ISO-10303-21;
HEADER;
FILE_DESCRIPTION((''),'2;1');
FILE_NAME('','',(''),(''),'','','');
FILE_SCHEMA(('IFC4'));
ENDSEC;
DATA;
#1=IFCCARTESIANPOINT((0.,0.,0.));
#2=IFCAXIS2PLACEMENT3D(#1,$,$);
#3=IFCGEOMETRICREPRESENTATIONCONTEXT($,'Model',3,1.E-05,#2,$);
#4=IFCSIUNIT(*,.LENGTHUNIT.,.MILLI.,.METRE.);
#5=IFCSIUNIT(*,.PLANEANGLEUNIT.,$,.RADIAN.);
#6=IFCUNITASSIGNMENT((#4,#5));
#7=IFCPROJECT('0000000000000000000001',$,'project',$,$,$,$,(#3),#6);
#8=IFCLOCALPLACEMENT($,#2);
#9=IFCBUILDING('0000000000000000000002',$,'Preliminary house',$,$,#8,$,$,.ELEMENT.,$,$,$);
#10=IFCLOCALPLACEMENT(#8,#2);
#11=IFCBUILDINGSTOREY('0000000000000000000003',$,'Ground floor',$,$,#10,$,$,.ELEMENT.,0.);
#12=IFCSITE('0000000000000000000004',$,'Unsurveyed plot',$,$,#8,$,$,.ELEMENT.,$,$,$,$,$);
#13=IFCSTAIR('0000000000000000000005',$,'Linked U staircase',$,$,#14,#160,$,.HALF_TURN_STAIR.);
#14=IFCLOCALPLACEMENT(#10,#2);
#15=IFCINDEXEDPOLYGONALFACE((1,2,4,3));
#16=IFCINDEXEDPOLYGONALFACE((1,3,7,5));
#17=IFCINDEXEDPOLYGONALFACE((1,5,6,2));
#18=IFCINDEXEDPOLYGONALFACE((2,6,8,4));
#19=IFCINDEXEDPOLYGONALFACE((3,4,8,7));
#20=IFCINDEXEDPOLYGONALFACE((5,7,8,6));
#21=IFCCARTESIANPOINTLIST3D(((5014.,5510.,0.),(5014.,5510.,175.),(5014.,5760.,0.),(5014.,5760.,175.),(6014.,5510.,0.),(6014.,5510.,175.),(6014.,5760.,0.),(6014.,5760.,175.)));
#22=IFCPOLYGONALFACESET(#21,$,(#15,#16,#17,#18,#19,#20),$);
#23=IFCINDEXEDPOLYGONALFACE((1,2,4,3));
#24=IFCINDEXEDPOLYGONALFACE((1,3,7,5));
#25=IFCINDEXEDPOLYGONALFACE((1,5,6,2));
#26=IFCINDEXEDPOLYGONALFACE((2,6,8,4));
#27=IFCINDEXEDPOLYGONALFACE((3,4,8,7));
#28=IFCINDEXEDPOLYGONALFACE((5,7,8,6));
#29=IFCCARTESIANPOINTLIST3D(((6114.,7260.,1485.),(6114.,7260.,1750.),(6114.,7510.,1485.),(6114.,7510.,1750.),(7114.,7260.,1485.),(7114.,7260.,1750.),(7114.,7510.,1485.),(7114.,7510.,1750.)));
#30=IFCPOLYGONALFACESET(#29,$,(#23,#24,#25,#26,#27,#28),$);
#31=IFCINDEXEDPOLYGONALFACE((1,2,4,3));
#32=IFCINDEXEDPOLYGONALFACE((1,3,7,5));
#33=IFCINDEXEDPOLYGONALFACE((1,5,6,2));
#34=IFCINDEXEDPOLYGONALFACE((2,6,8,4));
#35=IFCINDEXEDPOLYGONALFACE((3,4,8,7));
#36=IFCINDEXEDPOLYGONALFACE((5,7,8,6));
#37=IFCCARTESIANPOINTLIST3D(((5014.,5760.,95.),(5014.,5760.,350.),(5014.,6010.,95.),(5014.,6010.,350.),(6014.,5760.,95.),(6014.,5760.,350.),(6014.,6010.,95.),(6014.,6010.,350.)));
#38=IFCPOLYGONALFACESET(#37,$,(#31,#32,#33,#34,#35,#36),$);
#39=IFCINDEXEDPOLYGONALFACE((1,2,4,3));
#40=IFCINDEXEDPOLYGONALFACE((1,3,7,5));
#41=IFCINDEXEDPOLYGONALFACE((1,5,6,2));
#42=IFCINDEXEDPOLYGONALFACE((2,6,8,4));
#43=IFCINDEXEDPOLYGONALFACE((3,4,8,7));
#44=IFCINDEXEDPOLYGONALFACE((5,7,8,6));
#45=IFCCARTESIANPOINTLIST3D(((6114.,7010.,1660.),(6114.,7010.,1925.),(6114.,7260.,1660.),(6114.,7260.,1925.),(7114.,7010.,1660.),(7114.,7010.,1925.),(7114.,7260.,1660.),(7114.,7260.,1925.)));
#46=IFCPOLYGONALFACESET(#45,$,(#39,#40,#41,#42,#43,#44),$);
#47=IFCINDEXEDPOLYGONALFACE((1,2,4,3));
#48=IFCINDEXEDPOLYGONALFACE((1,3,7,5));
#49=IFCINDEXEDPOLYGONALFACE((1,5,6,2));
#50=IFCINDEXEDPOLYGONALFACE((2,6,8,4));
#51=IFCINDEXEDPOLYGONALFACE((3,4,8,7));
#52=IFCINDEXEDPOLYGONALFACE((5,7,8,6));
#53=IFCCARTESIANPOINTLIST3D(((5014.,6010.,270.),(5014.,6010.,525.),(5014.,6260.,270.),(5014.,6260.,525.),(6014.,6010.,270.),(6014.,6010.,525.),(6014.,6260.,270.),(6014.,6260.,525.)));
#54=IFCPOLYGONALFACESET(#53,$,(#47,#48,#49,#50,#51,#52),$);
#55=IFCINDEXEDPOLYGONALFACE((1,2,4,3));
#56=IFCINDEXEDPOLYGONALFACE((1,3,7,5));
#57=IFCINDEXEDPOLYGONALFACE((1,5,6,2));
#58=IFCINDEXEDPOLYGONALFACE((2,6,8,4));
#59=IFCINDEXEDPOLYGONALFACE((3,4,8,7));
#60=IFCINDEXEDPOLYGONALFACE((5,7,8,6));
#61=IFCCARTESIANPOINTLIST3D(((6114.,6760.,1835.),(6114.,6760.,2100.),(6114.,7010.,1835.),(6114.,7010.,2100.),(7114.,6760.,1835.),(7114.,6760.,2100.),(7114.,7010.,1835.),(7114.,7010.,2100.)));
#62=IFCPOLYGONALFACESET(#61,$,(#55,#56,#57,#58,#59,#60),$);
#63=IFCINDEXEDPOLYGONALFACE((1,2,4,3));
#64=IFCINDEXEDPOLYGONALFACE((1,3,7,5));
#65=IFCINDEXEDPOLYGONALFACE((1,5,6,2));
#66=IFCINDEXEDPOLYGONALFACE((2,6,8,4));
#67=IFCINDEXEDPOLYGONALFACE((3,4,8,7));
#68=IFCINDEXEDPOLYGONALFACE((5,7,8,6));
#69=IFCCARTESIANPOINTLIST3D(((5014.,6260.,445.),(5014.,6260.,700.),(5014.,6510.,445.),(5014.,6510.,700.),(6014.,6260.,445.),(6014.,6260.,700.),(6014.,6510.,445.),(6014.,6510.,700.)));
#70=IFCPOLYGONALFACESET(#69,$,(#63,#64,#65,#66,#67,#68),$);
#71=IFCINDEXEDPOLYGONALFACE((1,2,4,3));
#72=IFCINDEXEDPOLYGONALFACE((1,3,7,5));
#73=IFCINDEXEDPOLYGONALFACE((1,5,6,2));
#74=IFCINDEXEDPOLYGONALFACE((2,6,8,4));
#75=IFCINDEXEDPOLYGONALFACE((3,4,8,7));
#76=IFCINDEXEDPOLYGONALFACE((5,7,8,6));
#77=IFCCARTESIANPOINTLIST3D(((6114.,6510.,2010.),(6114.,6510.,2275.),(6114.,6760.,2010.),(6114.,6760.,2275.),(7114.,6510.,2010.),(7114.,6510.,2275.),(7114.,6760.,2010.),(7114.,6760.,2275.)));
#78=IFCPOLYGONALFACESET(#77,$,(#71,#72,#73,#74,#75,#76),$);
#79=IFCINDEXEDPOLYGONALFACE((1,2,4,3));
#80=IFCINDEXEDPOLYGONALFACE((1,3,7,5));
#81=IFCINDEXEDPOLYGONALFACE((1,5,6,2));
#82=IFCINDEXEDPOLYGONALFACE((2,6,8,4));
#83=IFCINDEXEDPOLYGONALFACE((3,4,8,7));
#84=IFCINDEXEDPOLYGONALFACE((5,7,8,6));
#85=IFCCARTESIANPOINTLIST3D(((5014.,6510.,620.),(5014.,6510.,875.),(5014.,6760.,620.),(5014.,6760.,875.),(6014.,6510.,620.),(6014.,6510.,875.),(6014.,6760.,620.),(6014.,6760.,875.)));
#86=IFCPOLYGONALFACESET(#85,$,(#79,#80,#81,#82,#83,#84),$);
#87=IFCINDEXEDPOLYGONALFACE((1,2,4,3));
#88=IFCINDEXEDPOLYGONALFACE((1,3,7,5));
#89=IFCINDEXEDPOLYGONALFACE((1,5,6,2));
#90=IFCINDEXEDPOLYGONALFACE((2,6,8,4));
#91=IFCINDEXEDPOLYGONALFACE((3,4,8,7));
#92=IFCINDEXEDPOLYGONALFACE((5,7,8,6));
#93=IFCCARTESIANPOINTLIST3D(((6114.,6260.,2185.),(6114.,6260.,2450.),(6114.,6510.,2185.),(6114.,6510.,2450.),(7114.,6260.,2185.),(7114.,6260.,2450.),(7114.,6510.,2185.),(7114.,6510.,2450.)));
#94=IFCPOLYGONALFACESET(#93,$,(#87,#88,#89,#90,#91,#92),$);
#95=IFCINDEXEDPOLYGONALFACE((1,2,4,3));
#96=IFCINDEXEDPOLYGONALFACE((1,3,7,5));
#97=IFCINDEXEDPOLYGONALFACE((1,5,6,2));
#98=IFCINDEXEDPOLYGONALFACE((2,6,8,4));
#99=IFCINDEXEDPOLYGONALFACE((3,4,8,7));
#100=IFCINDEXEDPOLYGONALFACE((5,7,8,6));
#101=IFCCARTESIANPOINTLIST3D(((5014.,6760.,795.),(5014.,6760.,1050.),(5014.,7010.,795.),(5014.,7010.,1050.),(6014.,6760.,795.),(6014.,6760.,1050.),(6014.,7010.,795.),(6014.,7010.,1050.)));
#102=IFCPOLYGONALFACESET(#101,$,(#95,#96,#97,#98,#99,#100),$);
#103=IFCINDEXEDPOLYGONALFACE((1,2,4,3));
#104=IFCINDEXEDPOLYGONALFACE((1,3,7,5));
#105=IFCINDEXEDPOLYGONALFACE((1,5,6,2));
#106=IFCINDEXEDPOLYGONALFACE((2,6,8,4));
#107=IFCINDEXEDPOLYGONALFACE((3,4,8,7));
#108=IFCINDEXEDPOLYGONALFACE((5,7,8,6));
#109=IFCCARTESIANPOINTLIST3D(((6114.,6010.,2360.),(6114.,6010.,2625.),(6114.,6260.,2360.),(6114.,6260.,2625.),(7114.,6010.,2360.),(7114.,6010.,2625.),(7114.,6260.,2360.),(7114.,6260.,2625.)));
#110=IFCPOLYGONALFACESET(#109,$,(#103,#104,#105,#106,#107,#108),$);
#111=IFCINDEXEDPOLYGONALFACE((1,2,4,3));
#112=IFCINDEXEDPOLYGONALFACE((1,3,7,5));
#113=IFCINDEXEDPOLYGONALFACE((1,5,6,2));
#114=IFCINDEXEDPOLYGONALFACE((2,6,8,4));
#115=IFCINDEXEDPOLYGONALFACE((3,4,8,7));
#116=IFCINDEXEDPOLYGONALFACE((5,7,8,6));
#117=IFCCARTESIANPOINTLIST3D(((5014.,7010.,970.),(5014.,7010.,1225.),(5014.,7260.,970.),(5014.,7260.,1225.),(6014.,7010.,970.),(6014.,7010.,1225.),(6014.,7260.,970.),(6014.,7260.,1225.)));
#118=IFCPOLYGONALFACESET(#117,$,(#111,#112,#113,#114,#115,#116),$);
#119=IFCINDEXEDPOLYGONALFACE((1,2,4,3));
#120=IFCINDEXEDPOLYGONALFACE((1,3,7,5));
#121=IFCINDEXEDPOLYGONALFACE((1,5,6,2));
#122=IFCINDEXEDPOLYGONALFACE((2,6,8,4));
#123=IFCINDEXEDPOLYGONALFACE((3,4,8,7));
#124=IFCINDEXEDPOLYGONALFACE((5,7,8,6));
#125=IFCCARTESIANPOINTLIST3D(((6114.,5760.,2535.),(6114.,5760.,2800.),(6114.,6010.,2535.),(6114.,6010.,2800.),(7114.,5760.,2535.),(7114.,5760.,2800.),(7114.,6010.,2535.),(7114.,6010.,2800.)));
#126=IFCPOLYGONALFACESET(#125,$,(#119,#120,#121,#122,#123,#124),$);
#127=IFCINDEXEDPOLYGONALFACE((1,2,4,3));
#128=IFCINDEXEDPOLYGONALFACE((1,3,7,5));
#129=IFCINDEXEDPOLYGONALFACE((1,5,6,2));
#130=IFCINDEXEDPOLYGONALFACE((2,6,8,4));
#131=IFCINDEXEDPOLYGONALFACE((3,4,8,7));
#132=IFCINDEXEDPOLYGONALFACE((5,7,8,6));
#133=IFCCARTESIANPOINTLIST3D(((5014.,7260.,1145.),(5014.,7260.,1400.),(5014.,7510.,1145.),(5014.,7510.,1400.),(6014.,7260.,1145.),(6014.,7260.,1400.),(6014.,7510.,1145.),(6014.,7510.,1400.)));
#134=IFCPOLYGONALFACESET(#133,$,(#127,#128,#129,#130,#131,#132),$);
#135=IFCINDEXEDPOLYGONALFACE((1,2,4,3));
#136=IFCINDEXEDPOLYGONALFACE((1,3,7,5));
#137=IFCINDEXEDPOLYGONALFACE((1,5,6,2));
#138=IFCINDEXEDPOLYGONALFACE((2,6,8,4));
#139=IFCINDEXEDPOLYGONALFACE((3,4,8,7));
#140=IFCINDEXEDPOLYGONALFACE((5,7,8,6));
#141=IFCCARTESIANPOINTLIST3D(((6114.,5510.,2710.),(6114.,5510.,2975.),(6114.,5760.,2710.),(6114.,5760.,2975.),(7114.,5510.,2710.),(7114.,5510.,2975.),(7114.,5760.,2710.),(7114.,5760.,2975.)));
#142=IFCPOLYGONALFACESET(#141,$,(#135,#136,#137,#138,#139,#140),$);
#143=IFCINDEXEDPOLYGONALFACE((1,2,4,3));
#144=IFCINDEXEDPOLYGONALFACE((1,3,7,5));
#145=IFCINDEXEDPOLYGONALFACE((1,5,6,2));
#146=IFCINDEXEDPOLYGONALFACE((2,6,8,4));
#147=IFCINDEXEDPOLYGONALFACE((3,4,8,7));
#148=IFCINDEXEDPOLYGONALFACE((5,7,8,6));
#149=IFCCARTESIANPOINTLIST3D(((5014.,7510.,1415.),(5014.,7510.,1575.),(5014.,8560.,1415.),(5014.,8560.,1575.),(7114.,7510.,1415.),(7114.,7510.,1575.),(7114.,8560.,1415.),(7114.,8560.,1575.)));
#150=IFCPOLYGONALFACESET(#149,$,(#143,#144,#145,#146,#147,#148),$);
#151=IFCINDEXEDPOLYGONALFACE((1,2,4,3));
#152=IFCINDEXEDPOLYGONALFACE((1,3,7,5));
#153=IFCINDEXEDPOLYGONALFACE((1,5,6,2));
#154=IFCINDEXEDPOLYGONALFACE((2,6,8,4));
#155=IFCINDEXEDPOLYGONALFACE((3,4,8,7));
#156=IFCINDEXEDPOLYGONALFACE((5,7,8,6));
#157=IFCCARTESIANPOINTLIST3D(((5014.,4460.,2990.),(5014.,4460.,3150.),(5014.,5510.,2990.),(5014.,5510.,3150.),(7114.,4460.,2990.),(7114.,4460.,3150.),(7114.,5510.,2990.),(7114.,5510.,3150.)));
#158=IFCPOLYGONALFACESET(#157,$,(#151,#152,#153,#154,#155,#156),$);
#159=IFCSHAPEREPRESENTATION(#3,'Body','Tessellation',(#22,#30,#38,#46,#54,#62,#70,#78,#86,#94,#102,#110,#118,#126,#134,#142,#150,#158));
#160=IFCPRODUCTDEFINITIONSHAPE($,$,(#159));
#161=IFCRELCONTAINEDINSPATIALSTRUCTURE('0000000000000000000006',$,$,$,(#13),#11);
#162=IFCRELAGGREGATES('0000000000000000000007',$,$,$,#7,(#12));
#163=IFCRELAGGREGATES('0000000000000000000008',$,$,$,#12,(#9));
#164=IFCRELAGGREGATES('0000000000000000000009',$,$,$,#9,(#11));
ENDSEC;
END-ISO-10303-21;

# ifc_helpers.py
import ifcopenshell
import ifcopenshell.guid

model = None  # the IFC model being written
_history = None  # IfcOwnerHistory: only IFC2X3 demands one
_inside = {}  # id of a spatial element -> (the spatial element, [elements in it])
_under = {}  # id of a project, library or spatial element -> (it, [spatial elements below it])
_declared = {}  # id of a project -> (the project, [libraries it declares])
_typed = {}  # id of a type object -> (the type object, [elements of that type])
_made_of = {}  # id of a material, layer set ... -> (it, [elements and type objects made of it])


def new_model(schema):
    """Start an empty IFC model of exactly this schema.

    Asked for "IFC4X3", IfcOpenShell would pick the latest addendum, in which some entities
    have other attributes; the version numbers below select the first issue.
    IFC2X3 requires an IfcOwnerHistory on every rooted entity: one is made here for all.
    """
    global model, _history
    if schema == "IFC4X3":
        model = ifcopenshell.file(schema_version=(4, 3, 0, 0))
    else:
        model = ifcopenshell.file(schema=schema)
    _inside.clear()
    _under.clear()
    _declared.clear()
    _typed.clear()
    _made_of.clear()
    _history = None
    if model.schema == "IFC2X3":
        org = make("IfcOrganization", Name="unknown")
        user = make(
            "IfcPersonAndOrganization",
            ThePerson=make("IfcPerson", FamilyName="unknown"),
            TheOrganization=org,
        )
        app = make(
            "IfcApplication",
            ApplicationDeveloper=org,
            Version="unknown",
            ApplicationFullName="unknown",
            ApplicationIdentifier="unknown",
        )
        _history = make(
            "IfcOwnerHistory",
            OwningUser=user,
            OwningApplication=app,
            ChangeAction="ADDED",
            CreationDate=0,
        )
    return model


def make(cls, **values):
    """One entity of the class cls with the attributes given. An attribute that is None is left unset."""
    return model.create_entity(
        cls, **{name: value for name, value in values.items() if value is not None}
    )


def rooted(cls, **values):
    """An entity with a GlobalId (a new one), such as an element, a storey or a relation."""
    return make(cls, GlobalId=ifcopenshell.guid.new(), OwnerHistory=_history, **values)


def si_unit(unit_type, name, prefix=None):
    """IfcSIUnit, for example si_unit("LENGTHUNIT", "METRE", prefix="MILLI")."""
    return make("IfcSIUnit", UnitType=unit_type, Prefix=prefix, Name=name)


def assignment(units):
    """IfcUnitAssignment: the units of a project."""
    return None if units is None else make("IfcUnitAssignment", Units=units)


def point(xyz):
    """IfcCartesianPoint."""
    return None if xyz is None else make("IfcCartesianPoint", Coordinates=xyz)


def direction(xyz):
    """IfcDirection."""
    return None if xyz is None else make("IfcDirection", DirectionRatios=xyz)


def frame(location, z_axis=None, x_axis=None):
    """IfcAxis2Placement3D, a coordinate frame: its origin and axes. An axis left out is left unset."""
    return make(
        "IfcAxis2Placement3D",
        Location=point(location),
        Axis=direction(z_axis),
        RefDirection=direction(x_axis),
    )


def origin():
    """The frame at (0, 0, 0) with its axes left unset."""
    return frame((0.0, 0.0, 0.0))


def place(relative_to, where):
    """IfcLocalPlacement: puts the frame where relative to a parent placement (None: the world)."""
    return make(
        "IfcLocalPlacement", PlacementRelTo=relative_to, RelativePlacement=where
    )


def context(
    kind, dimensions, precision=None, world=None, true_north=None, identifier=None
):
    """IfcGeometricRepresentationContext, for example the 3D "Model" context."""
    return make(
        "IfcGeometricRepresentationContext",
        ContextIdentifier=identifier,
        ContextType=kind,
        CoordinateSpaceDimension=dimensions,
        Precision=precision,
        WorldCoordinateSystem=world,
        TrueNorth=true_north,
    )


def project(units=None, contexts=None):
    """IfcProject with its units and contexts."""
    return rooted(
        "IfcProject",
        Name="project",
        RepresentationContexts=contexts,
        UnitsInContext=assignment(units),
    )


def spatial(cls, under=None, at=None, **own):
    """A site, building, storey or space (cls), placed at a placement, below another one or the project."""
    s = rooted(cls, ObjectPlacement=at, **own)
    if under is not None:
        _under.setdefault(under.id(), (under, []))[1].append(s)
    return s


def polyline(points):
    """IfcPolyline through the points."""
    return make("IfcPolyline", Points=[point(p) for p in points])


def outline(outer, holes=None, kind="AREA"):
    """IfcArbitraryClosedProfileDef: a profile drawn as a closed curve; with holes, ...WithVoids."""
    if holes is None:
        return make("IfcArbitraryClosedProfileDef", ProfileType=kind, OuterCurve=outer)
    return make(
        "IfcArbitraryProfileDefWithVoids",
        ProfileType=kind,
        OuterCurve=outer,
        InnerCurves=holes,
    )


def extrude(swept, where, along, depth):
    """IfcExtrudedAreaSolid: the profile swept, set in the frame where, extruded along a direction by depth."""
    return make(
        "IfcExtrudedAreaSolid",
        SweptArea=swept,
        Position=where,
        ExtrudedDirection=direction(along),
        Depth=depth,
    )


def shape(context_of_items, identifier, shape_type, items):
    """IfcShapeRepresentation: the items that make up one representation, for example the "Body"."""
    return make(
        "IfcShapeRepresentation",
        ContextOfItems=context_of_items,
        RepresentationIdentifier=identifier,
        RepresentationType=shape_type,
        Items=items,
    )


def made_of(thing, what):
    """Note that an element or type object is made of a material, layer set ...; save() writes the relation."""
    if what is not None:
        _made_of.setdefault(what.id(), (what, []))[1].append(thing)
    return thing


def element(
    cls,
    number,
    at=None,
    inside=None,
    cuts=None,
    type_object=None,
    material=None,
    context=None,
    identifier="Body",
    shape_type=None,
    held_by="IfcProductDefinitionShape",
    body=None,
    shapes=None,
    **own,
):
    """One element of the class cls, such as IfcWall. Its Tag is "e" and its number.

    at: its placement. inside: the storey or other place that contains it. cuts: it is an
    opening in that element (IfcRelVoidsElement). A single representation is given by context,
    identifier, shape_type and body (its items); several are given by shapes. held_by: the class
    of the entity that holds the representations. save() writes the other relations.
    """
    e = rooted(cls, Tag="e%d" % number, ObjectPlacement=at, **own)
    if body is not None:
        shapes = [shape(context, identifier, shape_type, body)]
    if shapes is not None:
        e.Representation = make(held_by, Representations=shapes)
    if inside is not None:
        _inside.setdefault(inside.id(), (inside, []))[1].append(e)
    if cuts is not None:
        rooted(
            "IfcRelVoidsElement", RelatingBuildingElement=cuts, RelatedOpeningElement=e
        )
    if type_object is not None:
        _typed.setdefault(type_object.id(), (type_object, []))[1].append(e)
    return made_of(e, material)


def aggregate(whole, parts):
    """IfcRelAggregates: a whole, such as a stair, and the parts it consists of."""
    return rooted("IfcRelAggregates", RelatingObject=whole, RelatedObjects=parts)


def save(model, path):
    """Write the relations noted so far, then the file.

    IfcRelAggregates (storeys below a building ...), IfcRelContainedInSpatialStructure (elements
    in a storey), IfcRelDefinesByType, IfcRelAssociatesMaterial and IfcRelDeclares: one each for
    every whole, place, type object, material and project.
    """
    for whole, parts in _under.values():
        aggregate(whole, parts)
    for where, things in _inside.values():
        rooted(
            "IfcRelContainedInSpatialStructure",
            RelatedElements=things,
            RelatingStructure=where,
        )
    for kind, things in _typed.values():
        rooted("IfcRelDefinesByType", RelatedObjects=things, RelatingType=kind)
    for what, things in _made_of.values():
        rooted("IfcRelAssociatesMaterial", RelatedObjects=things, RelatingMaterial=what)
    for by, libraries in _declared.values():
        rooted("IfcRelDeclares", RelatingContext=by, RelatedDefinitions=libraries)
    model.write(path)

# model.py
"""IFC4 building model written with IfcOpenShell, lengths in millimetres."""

from ifc_helpers import new_model, si_unit, frame, origin, place, context, project, spatial, polyline, outline, extrude, element, save


model = new_model("IFC4")

# Units and contexts
model_context = context("Model", 3, precision=1e-05, world=origin())
ifc_project = project(units=[si_unit("LENGTHUNIT", "METRE", prefix="MILLI"), si_unit("PLANEANGLEUNIT", "RADIAN")], contexts=[model_context])

# Site, building, storey
placement_1 = place(None, origin())
site = spatial("IfcSite", under=ifc_project, at=placement_1, Name="Unsurveyed plot", CompositionType="ELEMENT")
building = spatial("IfcBuilding", under=site, at=placement_1, Name="Preliminary house", CompositionType="ELEMENT")
placement_2 = place(placement_1, origin())
storey = spatial("IfcBuildingStorey", under=building, at=placement_2, Name="Ground floor", CompositionType="ELEMENT", Elevation=0.0)

# Stair
element("IfcStair", 1, at=placement_2, inside=storey, Name="Linked U staircase", PredefinedType="HALF_TURN_STAIR", context=model_context, shape_type="SweptSolid", body=[
    extrude(outline(polyline([(6014.0, 5510.0), (6014.0, 5760.0), (5014.0, 5760.0), (5014.0, 5510.0), (6014.0, 5510.0)])), origin(), (0.0, 0.0, 1.0), 175.0),
    extrude(outline(polyline([(7114.0, 7260.0), (7114.0, 7510.0), (6114.0, 7510.0), (6114.0, 7260.0), (7114.0, 7260.0)])), frame((0.0, 0.0, 1485.0)), (0.0, 0.0, 1.0), 265.0),
    extrude(outline(polyline([(6014.0, 5760.0), (6014.0, 6010.0), (5014.0, 6010.0), (5014.0, 5760.0), (6014.0, 5760.0)])), frame((0.0, 0.0, 95.0)), (0.0, 0.0, 1.0), 255.0),
    extrude(outline(polyline([(7114.0, 7010.0), (7114.0, 7260.0), (6114.0, 7260.0), (6114.0, 7010.0), (7114.0, 7010.0)])), frame((0.0, 0.0, 1660.0)), (0.0, 0.0, 1.0), 265.0),
    extrude(outline(polyline([(6014.0, 6010.0), (6014.0, 6260.0), (5014.0, 6260.0), (5014.0, 6010.0), (6014.0, 6010.0)])), frame((0.0, 0.0, 270.0)), (0.0, 0.0, 1.0), 255.0),
    extrude(outline(polyline([(7114.0, 6760.0), (7114.0, 7010.0), (6114.0, 7010.0), (6114.0, 6760.0), (7114.0, 6760.0)])), frame((0.0, 0.0, 1835.0)), (0.0, 0.0, 1.0), 265.0),
    extrude(outline(polyline([(6014.0, 6260.0), (6014.0, 6510.0), (5014.0, 6510.0), (5014.0, 6260.0), (6014.0, 6260.0)])), frame((0.0, 0.0, 445.0)), (0.0, 0.0, 1.0), 255.0),
    extrude(outline(polyline([(7114.0, 6510.0), (7114.0, 6760.0), (6114.0, 6760.0), (6114.0, 6510.0), (7114.0, 6510.0)])), frame((0.0, 0.0, 2010.0)), (0.0, 0.0, 1.0), 265.0),
    extrude(outline(polyline([(6014.0, 6510.0), (6014.0, 6760.0), (5014.0, 6760.0), (5014.0, 6510.0), (6014.0, 6510.0)])), frame((0.0, 0.0, 620.0)), (0.0, 0.0, 1.0), 255.0),
    extrude(outline(polyline([(7114.0, 6260.0), (7114.0, 6510.0), (6114.0, 6510.0), (6114.0, 6260.0), (7114.0, 6260.0)])), frame((0.0, 0.0, 2185.0)), (0.0, 0.0, 1.0), 265.0),
    extrude(outline(polyline([(6014.0, 6760.0), (6014.0, 7010.0), (5014.0, 7010.0), (5014.0, 6760.0), (6014.0, 6760.0)])), frame((0.0, 0.0, 795.0)), (0.0, 0.0, 1.0), 255.0),
    extrude(outline(polyline([(7114.0, 6010.0), (7114.0, 6260.0), (6114.0, 6260.0), (6114.0, 6010.0), (7114.0, 6010.0)])), frame((0.0, 0.0, 2360.0)), (0.0, 0.0, 1.0), 265.0),
    extrude(outline(polyline([(6014.0, 7010.0), (6014.0, 7260.0), (5014.0, 7260.0), (5014.0, 7010.0), (6014.0, 7010.0)])), frame((0.0, 0.0, 970.0)), (0.0, 0.0, 1.0), 255.0),
    extrude(outline(polyline([(7114.0, 5760.0), (7114.0, 6010.0), (6114.0, 6010.0), (6114.0, 5760.0), (7114.0, 5760.0)])), frame((0.0, 0.0, 2535.0)), (0.0, 0.0, 1.0), 265.0),
    extrude(outline(polyline([(6014.0, 7260.0), (6014.0, 7510.0), (5014.0, 7510.0), (5014.0, 7260.0), (6014.0, 7260.0)])), frame((0.0, 0.0, 1145.0)), (0.0, 0.0, 1.0), 255.0),
    extrude(outline(polyline([(7114.0, 5510.0), (7114.0, 5760.0), (6114.0, 5760.0), (6114.0, 5510.0), (7114.0, 5510.0)])), frame((0.0, 0.0, 2710.0)), (0.0, 0.0, 1.0), 265.0),
    extrude(outline(polyline([(7114.0, 7510.0), (7114.0, 8560.0), (5014.0, 8560.0), (5014.0, 7510.0), (7114.0, 7510.0)])), frame((0.0, 0.0, 1415.0)), (0.0, 0.0, 1.0), 160.0),
    extrude(outline(polyline([(7114.0, 4460.0), (7114.0, 5510.0), (5014.0, 5510.0), (5014.0, 4460.0), (7114.0, 4460.0)])), frame((0.0, 0.0, 2990.0)), (0.0, 0.0, 1.0), 160.0),
])

save(model, "model.ifc")
